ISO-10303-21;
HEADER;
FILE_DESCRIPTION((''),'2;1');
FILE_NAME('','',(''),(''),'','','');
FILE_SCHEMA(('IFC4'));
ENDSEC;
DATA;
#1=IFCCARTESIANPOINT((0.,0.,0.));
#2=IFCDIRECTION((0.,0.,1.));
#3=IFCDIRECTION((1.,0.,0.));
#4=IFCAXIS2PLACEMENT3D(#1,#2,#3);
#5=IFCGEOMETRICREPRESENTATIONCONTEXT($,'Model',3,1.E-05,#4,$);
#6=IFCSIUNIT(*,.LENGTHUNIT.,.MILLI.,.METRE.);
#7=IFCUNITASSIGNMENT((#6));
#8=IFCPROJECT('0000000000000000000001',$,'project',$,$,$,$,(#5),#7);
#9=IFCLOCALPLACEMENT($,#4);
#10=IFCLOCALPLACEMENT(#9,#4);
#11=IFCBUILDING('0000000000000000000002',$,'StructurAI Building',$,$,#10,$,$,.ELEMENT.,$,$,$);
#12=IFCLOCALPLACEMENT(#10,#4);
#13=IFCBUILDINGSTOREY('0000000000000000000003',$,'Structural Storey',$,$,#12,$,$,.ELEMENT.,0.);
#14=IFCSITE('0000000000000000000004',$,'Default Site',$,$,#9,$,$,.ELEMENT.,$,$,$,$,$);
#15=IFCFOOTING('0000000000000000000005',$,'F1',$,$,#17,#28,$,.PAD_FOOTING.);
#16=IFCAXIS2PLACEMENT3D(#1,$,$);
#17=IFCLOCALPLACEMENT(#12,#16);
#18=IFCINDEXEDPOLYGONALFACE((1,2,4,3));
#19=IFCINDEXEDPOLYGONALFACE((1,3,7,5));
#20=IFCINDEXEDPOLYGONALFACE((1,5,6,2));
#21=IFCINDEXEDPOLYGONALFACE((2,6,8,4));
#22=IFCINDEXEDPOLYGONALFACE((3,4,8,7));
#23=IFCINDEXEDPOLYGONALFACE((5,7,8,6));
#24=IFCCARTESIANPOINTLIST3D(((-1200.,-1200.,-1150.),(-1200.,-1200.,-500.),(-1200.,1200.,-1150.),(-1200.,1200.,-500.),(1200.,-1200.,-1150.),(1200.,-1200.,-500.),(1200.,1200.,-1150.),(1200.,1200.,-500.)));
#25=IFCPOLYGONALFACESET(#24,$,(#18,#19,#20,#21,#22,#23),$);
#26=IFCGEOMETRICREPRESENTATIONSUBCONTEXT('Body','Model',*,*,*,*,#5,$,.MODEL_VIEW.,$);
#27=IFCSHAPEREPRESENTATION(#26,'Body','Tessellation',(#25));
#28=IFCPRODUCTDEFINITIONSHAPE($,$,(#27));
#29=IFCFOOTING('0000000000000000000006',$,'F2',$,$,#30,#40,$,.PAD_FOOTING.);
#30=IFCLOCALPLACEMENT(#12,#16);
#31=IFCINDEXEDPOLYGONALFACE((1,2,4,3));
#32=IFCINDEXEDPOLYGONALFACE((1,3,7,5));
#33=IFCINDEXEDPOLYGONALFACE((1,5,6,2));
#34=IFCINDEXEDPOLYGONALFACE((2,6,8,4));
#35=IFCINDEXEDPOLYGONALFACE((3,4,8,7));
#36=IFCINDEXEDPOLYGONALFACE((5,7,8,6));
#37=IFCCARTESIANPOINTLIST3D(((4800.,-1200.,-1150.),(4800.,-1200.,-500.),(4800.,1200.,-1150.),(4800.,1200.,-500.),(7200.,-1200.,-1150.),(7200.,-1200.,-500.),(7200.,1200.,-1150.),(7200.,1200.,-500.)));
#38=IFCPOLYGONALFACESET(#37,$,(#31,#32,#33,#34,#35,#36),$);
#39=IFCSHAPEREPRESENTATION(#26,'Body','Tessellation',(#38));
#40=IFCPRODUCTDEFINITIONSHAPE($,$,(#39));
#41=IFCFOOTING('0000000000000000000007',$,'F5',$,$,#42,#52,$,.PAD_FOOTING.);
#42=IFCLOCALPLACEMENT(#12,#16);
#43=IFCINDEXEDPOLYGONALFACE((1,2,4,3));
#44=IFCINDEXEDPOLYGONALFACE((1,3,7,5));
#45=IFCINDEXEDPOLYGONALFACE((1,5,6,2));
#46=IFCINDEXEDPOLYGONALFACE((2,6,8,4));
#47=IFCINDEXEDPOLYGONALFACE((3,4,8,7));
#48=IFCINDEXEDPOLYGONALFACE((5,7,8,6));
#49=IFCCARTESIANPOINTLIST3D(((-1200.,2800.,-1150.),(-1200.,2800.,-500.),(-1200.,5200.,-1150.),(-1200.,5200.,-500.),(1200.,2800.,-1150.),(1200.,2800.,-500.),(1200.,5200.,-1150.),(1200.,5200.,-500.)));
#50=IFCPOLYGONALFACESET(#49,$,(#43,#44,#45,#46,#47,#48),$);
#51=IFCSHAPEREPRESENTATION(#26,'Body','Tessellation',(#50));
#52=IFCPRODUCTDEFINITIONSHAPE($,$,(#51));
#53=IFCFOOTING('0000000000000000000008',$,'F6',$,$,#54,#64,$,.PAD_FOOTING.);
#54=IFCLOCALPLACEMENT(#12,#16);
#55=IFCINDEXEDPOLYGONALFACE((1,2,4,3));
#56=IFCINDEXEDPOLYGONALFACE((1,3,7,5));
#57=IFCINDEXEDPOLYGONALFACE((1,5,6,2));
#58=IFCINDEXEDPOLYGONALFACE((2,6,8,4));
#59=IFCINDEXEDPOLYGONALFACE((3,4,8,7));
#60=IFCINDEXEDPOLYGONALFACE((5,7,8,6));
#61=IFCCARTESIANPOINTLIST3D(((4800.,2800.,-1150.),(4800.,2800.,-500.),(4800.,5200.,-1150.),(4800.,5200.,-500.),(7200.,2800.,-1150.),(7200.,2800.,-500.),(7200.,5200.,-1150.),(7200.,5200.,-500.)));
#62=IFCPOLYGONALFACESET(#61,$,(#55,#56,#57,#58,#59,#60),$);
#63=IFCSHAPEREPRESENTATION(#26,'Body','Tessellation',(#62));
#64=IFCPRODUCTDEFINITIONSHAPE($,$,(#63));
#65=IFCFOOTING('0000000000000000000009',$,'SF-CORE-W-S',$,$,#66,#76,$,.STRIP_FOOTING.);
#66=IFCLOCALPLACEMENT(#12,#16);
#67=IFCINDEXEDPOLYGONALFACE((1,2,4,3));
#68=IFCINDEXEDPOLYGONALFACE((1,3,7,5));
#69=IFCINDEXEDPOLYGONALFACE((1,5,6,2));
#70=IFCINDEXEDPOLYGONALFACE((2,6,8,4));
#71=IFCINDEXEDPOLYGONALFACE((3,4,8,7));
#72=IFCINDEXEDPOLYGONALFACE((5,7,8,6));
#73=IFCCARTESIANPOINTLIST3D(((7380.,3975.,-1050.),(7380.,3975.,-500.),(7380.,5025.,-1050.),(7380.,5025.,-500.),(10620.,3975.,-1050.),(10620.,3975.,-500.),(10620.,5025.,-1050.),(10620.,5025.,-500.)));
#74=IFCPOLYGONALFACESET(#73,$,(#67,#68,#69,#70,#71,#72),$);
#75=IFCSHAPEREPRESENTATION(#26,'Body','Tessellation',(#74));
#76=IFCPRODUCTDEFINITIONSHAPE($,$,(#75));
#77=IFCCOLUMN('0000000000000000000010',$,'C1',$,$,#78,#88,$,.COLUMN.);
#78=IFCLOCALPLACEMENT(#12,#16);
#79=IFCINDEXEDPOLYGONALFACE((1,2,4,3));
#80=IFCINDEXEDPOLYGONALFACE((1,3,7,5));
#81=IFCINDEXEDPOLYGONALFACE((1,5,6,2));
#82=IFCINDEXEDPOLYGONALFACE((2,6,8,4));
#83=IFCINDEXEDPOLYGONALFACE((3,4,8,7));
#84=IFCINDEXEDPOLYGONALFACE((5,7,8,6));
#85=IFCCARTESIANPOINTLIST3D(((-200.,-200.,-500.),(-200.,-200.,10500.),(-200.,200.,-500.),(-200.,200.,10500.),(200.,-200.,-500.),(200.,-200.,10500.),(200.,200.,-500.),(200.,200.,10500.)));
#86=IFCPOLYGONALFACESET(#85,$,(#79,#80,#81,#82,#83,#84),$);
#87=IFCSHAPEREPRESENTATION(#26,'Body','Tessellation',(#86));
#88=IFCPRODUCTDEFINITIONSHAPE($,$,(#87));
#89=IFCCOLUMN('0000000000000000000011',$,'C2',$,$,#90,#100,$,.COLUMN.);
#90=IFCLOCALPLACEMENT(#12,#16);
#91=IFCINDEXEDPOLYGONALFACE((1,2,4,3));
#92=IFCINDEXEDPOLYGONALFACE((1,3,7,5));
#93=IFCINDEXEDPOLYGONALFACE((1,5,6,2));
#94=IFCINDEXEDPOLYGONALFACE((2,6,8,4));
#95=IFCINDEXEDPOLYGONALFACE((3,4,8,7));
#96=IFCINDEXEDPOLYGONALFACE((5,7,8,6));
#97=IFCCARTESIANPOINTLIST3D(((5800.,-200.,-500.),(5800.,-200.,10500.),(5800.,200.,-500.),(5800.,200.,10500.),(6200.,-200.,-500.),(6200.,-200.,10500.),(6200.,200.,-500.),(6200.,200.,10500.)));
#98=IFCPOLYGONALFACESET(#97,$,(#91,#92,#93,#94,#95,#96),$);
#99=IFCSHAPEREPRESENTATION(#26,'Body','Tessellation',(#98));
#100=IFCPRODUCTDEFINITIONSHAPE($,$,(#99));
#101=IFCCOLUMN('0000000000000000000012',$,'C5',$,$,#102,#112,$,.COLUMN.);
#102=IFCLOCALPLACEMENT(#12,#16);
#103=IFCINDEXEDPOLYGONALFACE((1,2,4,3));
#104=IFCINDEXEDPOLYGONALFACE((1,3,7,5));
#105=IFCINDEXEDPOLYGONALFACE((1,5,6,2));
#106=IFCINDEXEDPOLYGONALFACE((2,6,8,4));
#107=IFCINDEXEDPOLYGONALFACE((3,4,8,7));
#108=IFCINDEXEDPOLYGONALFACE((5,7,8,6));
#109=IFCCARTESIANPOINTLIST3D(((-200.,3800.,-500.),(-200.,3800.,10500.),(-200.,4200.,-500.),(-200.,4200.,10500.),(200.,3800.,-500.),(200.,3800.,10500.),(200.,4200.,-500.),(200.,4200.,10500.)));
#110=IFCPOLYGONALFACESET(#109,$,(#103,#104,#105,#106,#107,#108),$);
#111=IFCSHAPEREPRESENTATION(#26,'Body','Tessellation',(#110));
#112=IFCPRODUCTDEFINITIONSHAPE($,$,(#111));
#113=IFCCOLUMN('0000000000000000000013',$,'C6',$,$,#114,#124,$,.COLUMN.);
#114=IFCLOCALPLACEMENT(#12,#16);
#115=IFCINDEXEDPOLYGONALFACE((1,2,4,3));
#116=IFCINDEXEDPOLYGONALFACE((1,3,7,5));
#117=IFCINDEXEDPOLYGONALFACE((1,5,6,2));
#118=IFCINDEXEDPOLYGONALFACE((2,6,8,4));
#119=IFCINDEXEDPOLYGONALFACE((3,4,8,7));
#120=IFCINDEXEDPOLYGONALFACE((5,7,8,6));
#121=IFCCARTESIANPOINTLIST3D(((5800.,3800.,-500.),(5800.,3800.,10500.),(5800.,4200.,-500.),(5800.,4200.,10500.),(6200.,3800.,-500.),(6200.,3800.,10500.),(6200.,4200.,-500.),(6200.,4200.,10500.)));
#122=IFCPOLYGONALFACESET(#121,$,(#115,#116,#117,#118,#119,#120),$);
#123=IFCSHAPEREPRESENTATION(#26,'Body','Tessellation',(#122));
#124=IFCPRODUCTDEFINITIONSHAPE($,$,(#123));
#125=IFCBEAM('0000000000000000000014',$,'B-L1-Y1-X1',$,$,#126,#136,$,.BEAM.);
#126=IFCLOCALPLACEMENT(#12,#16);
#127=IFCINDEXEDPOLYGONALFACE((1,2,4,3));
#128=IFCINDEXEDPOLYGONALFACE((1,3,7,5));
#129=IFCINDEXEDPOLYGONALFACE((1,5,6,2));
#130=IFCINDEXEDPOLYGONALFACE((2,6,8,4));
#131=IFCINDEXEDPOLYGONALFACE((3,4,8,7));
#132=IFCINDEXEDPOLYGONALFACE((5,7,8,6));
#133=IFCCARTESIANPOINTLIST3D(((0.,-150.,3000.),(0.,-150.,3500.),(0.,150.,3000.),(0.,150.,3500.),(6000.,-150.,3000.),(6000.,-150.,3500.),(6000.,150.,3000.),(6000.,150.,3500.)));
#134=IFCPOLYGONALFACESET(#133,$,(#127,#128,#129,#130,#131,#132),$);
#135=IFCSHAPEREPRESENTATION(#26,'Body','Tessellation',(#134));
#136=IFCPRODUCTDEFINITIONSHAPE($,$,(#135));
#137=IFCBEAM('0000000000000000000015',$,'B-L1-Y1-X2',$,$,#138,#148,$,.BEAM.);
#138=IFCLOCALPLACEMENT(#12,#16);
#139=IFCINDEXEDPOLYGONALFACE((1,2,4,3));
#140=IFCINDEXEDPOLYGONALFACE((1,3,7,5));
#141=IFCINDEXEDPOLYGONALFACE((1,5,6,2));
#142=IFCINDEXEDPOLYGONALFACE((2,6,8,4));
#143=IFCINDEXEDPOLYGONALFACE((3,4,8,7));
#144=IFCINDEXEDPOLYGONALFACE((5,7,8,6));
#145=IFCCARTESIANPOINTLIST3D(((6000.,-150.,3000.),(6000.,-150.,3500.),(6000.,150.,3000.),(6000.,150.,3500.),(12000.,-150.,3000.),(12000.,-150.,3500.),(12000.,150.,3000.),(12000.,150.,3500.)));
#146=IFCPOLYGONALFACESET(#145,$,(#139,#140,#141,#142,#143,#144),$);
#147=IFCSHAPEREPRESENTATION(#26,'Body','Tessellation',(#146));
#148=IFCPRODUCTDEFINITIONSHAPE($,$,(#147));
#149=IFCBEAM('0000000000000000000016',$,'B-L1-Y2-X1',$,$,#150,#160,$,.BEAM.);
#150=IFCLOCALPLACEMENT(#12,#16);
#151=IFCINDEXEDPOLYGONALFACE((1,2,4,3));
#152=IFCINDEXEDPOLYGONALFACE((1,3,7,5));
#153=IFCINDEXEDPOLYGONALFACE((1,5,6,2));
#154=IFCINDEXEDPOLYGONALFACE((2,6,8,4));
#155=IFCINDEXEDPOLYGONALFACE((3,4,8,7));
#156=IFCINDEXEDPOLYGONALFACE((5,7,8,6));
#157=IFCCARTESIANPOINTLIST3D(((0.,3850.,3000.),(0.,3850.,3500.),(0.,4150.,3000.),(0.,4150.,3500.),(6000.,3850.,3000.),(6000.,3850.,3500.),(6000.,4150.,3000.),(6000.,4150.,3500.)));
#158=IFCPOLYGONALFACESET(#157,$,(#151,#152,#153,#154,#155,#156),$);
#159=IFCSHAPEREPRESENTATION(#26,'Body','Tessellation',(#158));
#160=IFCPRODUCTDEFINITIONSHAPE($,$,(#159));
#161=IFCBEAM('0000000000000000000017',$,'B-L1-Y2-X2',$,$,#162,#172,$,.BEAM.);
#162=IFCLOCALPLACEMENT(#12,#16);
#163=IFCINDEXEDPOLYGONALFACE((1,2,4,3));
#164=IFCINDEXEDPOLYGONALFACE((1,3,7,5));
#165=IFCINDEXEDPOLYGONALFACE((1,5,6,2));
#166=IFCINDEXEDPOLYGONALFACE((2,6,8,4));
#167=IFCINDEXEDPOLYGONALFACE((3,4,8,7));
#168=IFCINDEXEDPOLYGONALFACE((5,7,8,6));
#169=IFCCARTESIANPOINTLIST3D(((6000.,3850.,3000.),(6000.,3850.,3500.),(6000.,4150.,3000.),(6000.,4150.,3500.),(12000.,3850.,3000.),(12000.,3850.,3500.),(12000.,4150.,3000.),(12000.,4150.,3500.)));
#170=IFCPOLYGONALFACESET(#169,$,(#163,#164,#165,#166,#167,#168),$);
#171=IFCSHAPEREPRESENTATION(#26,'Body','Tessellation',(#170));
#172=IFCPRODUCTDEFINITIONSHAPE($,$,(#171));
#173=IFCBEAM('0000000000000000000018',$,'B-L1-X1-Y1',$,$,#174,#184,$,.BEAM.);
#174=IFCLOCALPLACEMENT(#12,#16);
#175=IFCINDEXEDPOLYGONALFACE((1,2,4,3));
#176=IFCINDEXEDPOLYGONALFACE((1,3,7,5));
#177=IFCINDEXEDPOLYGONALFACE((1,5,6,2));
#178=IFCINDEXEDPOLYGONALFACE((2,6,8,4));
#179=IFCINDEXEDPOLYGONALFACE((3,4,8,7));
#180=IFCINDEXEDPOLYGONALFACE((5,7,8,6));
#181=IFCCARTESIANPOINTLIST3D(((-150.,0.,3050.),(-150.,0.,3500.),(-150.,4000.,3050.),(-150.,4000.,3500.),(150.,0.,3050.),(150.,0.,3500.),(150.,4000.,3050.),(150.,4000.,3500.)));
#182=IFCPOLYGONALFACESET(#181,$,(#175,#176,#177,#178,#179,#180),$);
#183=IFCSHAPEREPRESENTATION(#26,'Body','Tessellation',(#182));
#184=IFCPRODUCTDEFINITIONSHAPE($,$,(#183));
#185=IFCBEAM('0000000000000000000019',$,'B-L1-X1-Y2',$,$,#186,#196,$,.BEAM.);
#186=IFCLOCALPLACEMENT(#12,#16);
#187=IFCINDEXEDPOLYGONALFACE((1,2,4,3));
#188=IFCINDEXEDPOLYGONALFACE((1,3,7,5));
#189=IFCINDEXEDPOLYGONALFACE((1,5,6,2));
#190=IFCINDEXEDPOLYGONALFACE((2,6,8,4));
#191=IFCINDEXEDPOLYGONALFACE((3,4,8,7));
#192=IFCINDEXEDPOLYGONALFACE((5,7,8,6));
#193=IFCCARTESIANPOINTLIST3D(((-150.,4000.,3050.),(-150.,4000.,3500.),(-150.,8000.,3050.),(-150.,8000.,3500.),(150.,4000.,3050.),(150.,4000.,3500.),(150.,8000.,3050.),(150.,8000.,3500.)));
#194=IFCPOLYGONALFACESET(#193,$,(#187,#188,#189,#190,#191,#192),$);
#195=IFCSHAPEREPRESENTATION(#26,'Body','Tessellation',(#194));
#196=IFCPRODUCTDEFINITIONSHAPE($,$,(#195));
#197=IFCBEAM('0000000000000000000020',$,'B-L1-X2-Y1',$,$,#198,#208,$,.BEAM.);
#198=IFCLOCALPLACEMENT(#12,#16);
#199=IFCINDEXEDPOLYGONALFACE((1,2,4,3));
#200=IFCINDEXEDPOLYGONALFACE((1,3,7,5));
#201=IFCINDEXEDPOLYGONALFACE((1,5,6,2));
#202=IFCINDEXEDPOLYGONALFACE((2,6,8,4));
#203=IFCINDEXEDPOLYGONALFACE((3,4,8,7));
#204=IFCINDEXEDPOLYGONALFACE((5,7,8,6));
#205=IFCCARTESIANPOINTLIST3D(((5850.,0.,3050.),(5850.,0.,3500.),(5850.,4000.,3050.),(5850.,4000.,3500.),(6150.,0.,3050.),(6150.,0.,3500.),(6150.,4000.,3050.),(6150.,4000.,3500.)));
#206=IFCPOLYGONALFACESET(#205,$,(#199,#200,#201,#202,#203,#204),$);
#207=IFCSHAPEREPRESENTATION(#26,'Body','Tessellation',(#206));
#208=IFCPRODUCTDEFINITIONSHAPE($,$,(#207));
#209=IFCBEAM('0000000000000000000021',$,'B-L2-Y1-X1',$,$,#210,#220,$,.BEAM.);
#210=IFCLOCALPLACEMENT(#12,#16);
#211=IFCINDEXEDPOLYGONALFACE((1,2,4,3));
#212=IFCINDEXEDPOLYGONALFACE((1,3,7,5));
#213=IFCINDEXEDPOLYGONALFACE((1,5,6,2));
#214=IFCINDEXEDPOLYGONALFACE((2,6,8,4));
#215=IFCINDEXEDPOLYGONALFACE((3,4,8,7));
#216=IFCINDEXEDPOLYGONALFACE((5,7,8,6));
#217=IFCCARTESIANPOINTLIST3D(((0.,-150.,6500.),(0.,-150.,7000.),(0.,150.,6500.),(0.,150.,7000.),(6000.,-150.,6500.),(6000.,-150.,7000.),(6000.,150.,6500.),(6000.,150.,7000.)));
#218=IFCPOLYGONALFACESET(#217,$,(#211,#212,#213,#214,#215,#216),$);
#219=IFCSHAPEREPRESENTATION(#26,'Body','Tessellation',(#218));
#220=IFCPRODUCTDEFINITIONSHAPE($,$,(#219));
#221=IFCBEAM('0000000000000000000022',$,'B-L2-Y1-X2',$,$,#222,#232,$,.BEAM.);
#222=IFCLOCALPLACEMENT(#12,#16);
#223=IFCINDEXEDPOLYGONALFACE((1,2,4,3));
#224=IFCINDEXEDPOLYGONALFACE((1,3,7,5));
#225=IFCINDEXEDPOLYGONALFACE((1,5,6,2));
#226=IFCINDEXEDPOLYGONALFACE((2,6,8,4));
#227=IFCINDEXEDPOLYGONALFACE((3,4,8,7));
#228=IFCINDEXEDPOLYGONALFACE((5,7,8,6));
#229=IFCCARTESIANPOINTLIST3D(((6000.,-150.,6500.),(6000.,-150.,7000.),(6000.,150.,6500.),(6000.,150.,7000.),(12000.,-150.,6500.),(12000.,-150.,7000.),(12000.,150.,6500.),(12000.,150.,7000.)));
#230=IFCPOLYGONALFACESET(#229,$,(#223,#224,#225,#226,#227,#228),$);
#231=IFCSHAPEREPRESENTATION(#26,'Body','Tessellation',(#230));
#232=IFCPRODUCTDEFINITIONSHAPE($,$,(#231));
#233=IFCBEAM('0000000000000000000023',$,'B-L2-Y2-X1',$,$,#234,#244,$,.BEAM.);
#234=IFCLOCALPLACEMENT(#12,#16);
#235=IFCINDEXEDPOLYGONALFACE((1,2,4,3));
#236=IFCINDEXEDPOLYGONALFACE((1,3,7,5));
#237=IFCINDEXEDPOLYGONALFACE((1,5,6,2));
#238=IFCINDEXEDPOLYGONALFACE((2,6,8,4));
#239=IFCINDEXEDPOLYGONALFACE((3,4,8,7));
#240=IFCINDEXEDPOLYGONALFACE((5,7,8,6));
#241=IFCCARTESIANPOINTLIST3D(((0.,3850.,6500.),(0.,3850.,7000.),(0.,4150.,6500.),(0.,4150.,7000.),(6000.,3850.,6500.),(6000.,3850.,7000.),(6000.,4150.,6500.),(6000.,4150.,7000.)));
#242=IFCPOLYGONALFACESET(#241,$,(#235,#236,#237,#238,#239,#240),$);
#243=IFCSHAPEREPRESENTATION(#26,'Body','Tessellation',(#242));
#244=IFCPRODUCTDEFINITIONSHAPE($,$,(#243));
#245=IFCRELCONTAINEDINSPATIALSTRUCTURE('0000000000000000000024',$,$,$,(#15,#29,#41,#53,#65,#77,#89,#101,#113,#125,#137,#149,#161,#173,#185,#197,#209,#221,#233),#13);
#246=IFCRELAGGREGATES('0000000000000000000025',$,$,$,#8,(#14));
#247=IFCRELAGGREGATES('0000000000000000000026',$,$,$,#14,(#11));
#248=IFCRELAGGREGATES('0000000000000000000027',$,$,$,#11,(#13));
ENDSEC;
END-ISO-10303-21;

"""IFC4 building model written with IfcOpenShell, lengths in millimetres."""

from ifc_helpers import new_model, si_unit, frame, origin_with_axes, place, context, subcontext, project, spatial, rectangle, extrude, element, save


model = new_model("IFC4")

# Units and contexts
model_context = context("Model", 3, precision=1e-05, world=origin_with_axes())
body_context = subcontext(model_context, "Body", "Model", "MODEL_VIEW")
ifc_project = project(units=[si_unit("LENGTHUNIT", "METRE", prefix="MILLI")], contexts=[model_context])

# Site, building, storey
site_placement = place(None, origin_with_axes())
site = spatial("IfcSite", under=ifc_project, at=site_placement, Name="Default Site", CompositionType="ELEMENT")
building_placement = place(site_placement, origin_with_axes())
building = spatial("IfcBuilding", under=site, at=building_placement, Name="StructurAI Building", CompositionType="ELEMENT")
storey_placement = place(building_placement, origin_with_axes())
storey = spatial("IfcBuildingStorey", under=building, at=storey_placement, Name="Structural Storey", CompositionType="ELEMENT", Elevation=0.0)

# Footings
for number, where, z_axis, x_axis, name in (
    (1, (0.0, 0.0, -1150.0), (0.0, 0.0, 1.0), (1.0, 0.0, 0.0), "F1"),
    (2, (6000.0, 0.0, -1150.0), (0.0, 0.0, 1.0), (1.0, 0.0, 0.0), "F2"),
    (3, (0.0, 4000.0, -1150.0), (0.0, 0.0, 1.0), (1.0, 0.0, 0.0), "F5"),
    (4, (6000.0, 4000.0, -1150.0), (0.0, 0.0, 1.0), (1.0, 0.0, 0.0), "F6"),
):
    element("IfcFooting", number, at=place(storey_placement, frame(where, z_axis=z_axis, x_axis=x_axis)), inside=storey, Name=name, PredefinedType="PAD_FOOTING", context=body_context, shape_type="SweptSolid", body=[
        extrude(rectangle(XDim=2400.0, YDim=2400.0), origin_with_axes(), (0.0, 0.0, 1.0), 650.0),
    ])
footing_placement = place(storey_placement, frame((9000.0, 4500.0, -1050.0), z_axis=(0.0, 0.0, 1.0), x_axis=(1.0, 0.0, 0.0)))
element("IfcFooting", 5, at=footing_placement, inside=storey, Name="SF-CORE-W-S", PredefinedType="STRIP_FOOTING", context=body_context, shape_type="SweptSolid", body=[
    extrude(rectangle(XDim=3240.0, YDim=1050.0), origin_with_axes(), (0.0, 0.0, 1.0), 550.0),
])

# Columns
for number, where, z_axis, x_axis, name in (
    (6, (0.0, 0.0, -500.0), (0.0, 0.0, 1.0), (1.0, 0.0, 0.0), "C1"),
    (7, (6000.0, 0.0, -500.0), (0.0, 0.0, 1.0), (1.0, 0.0, 0.0), "C2"),
    (8, (0.0, 4000.0, -500.0), (0.0, 0.0, 1.0), (1.0, 0.0, 0.0), "C5"),
    (9, (6000.0, 4000.0, -500.0), (0.0, 0.0, 1.0), (1.0, 0.0, 0.0), "C6"),
):
    element("IfcColumn", number, at=place(storey_placement, frame(where, z_axis=z_axis, x_axis=x_axis)), inside=storey, Name=name, PredefinedType="COLUMN", context=body_context, shape_type="SweptSolid", body=[
        extrude(rectangle(XDim=400.0, YDim=400.0), origin_with_axes(), (0.0, 0.0, 1.0), 11000.0),
    ])

# Beams
for number, where, z_axis, x_axis, name in (
    (10, (3000.0, 0.0, 3000.0), (0.0, 0.0, 1.0), (1.0, 0.0, 0.0), "B-L1-Y1-X1"),
    (11, (9000.0, 0.0, 3000.0), (0.0, 0.0, 1.0), (1.0, 0.0, 0.0), "B-L1-Y1-X2"),
    (12, (3000.0, 4000.0, 3000.0), (0.0, 0.0, 1.0), (1.0, 0.0, 0.0), "B-L1-Y2-X1"),
    (13, (9000.0, 4000.0, 3000.0), (0.0, 0.0, 1.0), (1.0, 0.0, 0.0), "B-L1-Y2-X2"),
):
    element("IfcBeam", number, at=place(storey_placement, frame(where, z_axis=z_axis, x_axis=x_axis)), inside=storey, Name=name, PredefinedType="BEAM", context=body_context, shape_type="SweptSolid", body=[
        extrude(rectangle(XDim=6000.0, YDim=300.0), origin_with_axes(), (0.0, 0.0, 1.0), 500.0),
    ])
for number, where, z_axis, x_axis, name in (
    (14, (0.0, 2000.0, 3050.0), (0.0, 0.0, 1.0), (0.0, 1.0, 0.0), "B-L1-X1-Y1"),
    (15, (0.0, 6000.0, 3050.0), (0.0, 0.0, 1.0), (0.0, 1.0, 0.0), "B-L1-X1-Y2"),
    (16, (6000.0, 2000.0, 3050.0), (0.0, 0.0, 1.0), (0.0, 1.0, 0.0), "B-L1-X2-Y1"),
):
    element("IfcBeam", number, at=place(storey_placement, frame(where, z_axis=z_axis, x_axis=x_axis)), inside=storey, Name=name, PredefinedType="BEAM", context=body_context, shape_type="SweptSolid", body=[
        extrude(rectangle(XDim=4000.0, YDim=300.0), origin_with_axes(), (0.0, 0.0, 1.0), 450.0),
    ])
for number, where, z_axis, x_axis, name in (
    (17, (3000.0, 0.0, 6500.0), (0.0, 0.0, 1.0), (1.0, 0.0, 0.0), "B-L2-Y1-X1"),
    (18, (9000.0, 0.0, 6500.0), (0.0, 0.0, 1.0), (1.0, 0.0, 0.0), "B-L2-Y1-X2"),
    (19, (3000.0, 4000.0, 6500.0), (0.0, 0.0, 1.0), (1.0, 0.0, 0.0), "B-L2-Y2-X1"),
):
    element("IfcBeam", number, at=place(storey_placement, frame(where, z_axis=z_axis, x_axis=x_axis)), inside=storey, Name=name, PredefinedType="BEAM", context=body_context, shape_type="SweptSolid", body=[
        extrude(rectangle(XDim=6000.0, YDim=300.0), origin_with_axes(), (0.0, 0.0, 1.0), 500.0),
    ])

save(model, "model.ifc")
